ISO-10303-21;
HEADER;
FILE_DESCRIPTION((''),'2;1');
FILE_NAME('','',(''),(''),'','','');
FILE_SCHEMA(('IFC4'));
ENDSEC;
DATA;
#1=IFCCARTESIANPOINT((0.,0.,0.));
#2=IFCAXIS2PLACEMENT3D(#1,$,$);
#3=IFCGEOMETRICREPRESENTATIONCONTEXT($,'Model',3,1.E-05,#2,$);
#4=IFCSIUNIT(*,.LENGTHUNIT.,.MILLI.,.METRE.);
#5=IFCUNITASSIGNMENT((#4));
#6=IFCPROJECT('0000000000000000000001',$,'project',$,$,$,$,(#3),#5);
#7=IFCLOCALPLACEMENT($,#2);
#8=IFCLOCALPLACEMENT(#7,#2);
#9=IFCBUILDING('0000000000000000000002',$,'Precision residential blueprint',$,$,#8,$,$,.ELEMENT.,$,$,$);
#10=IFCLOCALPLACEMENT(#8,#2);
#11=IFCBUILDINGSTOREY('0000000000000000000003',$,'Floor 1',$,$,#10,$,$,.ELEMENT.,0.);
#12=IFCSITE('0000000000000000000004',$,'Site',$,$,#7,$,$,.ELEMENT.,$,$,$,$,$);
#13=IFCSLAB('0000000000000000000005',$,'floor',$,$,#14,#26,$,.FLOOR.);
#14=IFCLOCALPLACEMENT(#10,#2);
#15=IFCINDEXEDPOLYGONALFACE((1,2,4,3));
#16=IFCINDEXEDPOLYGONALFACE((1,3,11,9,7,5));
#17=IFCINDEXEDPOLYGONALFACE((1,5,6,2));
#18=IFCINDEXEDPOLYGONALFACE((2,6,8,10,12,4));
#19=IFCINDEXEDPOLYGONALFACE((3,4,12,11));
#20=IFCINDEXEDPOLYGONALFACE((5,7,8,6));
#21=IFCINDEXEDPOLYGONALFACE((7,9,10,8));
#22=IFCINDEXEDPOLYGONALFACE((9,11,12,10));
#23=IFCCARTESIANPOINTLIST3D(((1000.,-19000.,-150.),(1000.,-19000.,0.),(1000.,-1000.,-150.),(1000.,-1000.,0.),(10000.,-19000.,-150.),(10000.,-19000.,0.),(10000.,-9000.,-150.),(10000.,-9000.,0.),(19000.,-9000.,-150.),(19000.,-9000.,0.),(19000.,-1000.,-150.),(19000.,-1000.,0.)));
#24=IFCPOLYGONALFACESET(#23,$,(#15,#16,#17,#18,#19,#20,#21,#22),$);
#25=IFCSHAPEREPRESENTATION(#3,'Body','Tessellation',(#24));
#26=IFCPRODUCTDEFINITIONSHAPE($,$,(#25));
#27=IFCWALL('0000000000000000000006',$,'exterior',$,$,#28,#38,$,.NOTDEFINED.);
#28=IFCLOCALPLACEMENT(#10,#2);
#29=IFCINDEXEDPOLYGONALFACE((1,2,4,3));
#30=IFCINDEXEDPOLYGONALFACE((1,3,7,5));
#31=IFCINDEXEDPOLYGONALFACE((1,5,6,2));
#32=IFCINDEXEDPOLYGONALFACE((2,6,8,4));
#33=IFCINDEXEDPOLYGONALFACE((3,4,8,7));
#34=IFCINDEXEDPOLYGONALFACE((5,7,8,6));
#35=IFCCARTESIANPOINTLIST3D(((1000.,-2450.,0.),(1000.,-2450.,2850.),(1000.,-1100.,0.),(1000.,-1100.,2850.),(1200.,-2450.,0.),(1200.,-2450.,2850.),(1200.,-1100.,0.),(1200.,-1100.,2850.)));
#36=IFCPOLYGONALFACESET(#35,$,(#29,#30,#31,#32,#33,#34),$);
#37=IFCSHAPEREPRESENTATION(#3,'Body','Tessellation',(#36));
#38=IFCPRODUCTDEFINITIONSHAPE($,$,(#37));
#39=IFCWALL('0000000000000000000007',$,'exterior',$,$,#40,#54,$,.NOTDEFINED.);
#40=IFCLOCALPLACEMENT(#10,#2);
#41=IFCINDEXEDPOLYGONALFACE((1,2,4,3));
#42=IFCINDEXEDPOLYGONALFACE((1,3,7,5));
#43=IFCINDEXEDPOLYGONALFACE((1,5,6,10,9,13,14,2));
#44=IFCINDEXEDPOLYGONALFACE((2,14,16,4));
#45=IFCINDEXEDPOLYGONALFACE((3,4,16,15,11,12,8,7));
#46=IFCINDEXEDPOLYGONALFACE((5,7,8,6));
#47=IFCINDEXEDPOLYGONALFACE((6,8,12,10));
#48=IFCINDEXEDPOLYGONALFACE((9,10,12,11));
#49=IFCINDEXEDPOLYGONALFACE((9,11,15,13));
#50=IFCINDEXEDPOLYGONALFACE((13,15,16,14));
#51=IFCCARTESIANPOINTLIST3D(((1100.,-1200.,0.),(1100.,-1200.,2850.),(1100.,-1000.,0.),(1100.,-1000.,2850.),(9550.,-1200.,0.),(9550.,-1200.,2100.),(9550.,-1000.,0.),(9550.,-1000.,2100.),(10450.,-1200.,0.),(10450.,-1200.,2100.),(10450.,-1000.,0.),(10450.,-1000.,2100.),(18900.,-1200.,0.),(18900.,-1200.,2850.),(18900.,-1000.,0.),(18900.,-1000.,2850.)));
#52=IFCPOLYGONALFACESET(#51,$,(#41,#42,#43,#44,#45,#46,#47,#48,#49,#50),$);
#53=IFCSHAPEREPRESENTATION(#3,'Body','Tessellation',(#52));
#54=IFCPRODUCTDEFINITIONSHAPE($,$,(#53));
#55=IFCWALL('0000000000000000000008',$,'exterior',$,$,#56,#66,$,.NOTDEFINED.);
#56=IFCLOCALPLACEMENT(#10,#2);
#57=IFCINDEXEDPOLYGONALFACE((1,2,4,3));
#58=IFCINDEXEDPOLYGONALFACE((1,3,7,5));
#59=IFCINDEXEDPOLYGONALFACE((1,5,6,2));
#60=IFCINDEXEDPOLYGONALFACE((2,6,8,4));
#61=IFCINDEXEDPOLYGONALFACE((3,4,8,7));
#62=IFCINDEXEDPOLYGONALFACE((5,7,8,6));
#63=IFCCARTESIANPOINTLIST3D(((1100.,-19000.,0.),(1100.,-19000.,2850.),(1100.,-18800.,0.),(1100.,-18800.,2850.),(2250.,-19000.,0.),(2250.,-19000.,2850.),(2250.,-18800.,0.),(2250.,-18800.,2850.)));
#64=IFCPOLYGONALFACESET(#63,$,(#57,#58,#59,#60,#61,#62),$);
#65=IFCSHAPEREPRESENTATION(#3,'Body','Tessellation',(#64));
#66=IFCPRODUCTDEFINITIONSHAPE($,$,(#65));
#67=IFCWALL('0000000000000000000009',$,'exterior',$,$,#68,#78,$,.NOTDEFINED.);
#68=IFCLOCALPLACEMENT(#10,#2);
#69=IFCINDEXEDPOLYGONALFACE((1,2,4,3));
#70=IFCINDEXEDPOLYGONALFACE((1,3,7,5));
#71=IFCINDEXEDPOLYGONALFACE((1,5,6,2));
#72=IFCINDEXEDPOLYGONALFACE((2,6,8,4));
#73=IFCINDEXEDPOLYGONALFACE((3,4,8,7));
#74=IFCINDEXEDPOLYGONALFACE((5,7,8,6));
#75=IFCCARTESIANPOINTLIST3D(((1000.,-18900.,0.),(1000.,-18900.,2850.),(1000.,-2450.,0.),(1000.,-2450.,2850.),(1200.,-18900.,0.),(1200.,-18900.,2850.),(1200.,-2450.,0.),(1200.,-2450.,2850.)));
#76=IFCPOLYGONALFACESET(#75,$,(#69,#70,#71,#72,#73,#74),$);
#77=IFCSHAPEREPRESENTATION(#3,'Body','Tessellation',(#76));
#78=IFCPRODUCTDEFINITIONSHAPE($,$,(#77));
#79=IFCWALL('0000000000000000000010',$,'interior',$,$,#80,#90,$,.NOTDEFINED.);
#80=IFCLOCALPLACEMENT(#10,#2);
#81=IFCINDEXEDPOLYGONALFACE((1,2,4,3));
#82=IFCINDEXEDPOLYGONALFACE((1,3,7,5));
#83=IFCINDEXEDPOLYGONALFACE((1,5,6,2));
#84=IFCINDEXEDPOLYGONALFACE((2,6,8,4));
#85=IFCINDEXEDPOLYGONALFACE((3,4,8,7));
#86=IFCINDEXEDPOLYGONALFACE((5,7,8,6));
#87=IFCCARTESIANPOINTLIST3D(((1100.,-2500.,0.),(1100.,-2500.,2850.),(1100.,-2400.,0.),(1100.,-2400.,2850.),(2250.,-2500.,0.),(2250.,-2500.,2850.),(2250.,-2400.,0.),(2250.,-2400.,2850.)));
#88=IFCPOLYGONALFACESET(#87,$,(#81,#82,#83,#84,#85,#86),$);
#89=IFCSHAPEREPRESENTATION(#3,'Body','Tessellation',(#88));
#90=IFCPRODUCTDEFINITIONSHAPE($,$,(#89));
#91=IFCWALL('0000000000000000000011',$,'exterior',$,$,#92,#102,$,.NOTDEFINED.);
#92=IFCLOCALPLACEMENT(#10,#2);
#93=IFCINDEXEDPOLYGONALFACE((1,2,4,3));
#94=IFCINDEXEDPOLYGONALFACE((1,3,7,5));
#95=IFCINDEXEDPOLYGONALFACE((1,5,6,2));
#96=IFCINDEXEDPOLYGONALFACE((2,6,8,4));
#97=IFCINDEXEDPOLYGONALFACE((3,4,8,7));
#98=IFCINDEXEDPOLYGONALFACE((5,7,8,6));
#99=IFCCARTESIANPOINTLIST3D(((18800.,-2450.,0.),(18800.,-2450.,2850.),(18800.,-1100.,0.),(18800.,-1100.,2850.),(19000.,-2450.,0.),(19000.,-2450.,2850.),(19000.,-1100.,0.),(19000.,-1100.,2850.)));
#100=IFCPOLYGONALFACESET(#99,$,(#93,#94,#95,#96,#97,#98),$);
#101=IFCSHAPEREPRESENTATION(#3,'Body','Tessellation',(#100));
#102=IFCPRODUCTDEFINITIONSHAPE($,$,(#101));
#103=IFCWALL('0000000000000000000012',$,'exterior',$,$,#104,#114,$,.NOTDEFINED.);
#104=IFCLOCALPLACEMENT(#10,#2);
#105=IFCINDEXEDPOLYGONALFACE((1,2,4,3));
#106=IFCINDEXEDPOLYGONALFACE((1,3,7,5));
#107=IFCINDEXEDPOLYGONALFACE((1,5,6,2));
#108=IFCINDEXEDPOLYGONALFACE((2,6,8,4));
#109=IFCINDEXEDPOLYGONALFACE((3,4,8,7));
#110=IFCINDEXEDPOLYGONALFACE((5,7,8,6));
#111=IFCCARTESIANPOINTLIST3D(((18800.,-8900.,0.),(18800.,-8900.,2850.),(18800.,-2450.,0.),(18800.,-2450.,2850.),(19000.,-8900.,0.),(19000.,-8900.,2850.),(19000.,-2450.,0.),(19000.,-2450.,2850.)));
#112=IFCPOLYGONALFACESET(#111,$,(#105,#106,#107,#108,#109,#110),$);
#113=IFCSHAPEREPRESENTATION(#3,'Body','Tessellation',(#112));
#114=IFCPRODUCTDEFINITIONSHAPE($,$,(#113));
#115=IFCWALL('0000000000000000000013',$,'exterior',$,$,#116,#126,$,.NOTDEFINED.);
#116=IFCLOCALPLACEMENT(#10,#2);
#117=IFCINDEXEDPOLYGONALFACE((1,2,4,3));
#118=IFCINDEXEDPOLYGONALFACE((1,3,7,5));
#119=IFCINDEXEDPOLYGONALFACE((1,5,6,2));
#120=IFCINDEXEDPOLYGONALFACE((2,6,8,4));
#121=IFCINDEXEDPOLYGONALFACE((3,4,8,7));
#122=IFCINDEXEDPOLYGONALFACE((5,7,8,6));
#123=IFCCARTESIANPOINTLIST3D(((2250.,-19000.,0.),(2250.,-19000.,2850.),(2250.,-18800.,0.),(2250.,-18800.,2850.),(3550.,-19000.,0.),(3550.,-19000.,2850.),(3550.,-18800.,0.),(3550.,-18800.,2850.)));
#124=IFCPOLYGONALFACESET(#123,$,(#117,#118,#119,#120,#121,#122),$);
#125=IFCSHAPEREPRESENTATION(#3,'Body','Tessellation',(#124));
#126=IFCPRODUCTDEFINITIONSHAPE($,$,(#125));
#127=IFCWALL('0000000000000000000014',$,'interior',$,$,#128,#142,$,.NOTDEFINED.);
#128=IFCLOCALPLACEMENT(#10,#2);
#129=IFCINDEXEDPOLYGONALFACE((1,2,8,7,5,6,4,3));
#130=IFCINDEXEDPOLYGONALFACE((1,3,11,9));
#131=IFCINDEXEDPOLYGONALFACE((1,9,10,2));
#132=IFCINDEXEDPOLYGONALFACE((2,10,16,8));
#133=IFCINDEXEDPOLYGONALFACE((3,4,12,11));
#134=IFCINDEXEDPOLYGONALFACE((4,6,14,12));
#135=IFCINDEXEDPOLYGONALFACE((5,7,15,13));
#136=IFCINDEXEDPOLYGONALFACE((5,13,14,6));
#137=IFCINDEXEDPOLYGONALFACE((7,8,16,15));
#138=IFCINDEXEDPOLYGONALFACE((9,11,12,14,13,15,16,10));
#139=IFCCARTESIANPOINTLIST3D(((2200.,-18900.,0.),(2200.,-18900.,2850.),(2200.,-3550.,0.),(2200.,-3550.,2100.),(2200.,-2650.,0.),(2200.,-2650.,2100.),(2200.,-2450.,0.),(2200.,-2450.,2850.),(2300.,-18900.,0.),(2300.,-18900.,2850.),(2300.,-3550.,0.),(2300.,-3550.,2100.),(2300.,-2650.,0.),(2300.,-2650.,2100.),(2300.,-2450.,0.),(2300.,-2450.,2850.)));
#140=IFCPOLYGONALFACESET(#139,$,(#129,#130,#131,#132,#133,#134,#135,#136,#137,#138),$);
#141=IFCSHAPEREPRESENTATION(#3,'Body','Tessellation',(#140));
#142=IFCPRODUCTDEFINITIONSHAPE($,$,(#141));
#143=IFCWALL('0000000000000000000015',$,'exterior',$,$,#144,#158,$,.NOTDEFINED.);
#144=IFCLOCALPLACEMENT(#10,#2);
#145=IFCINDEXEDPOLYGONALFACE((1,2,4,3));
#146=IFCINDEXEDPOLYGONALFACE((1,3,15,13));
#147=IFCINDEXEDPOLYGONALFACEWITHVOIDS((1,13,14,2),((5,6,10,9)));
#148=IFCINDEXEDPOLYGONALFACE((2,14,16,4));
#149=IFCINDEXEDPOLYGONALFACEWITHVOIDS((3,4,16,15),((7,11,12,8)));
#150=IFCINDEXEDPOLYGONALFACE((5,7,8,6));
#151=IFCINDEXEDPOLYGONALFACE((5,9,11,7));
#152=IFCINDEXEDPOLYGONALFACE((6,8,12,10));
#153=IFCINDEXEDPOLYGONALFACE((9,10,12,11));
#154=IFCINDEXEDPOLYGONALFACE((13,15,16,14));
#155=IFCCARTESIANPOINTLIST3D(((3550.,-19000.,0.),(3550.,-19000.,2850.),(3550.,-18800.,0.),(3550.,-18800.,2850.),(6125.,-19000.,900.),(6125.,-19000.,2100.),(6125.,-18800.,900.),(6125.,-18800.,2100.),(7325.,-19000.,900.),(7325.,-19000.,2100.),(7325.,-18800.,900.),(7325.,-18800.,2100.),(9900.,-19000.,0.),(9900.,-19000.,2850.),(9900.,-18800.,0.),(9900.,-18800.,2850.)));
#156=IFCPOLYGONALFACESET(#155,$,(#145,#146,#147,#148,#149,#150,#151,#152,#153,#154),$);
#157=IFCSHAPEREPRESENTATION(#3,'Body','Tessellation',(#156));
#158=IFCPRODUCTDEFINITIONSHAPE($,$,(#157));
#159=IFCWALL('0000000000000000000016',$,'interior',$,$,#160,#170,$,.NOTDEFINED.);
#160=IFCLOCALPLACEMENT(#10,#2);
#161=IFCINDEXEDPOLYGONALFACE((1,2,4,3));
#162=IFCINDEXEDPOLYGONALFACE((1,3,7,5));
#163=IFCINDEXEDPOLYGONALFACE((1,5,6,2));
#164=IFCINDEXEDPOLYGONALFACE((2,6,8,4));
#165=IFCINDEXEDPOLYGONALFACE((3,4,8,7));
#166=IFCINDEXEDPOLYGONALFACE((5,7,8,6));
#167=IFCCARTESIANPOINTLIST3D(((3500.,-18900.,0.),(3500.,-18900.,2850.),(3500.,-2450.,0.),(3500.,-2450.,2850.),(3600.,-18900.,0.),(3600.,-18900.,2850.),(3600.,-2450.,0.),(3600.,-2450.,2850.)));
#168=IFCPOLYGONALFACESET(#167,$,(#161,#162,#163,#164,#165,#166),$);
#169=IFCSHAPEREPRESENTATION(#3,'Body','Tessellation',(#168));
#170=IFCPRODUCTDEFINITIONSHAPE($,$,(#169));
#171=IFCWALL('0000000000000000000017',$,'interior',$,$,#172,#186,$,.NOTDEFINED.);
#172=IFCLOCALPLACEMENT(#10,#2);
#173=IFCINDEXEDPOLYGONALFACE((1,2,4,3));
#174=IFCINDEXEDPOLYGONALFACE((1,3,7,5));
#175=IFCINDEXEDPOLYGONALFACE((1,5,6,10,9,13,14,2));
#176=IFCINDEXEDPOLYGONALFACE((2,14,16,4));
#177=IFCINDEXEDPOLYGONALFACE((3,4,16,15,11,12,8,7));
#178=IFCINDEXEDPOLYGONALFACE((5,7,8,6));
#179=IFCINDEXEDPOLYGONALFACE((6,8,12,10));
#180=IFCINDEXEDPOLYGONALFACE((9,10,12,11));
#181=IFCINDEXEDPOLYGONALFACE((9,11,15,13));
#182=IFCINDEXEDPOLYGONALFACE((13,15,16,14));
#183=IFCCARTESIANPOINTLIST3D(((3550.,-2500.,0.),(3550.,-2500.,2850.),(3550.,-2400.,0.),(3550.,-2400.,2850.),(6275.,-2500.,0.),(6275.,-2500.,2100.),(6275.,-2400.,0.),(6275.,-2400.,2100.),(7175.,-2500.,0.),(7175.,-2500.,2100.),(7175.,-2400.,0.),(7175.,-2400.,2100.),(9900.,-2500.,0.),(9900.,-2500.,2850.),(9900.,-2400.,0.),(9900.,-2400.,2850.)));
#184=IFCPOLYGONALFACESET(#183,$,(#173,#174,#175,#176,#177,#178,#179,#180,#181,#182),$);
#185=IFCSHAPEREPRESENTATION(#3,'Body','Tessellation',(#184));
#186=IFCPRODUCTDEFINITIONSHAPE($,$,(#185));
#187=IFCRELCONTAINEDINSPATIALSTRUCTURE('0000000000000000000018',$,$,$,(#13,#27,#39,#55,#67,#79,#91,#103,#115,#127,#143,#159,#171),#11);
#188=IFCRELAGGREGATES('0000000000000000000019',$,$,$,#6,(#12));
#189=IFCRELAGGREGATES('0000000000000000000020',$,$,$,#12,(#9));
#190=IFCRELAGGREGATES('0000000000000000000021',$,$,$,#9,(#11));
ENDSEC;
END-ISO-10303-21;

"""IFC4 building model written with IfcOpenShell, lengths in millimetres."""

from ifc_helpers import new_model, si_unit, frame, origin, place, context, project, spatial, polyline, outline, extrude, element, save


model = new_model("IFC4")

# Units and contexts
model_context = context("Model", 3, precision=1e-05, world=origin())
ifc_project = project(units=[si_unit("LENGTHUNIT", "METRE", prefix="MILLI")], contexts=[model_context])

# Site, building, storey
site_placement = place(None, origin())
site = spatial("IfcSite", under=ifc_project, at=site_placement, Name="Site", CompositionType="ELEMENT")
building_placement = place(site_placement, origin())
building = spatial("IfcBuilding", under=site, at=building_placement, Name="Precision residential blueprint", CompositionType="ELEMENT")
storey_placement = place(building_placement, origin())
storey = spatial("IfcBuildingStorey", under=building, at=storey_placement, Name="Floor 1", CompositionType="ELEMENT", Elevation=0.0)

# Slab
slab_placement = place(storey_placement, origin())
element("IfcSlab", 1, at=slab_placement, inside=storey, Name="floor", PredefinedType="FLOOR", context=model_context, shape_type="SweptSolid", body=[
    extrude(outline(polyline([(1000.0, -19000.0), (10000.0, -19000.0), (10000.0, -9000.0), (19000.0, -9000.0), (19000.0, -1000.0), (1000.0, -1000.0), (1000.0, -19000.0)])), frame((0.0, 0.0, -150.0)), (0.0, 0.0, 1.0), 150.0),
])

# Wall
wall_1_placement = place(storey_placement, origin())
element("IfcWall", 2, at=wall_1_placement, inside=storey, Name="exterior", PredefinedType="NOTDEFINED", context=model_context, shape_type="SweptSolid", body=[
    extrude(outline(polyline([(1200.0, -1100.0), (1200.0, -2450.0), (1000.0, -2450.0), (1000.0, -1100.0), (1200.0, -1100.0)])), origin(), (0.0, 0.0, 1.0), 2850.0),
])

# Wall, opening
wall_2_placement = place(storey_placement, origin())
wall_2 = element("IfcWall", 3, at=wall_2_placement, inside=storey, Name="exterior", PredefinedType="NOTDEFINED", context=model_context, shape_type="SweptSolid", body=[
    extrude(outline(polyline([(1100.0, -1000.0), (18900.0, -1000.0), (18900.0, -1200.0), (1100.0, -1200.0), (1100.0, -1000.0)])), origin(), (0.0, 0.0, 1.0), 2850.0),
])
opening_1_placement = place(storey_placement, origin())
element("IfcOpeningElement", 4, at=opening_1_placement, cuts=wall_2, PredefinedType="OPENING", context=model_context, shape_type="SweptSolid", body=[
    extrude(outline(polyline([(9550.0, -1000.0), (10450.0, -1000.0), (10450.0, -1200.0), (9550.0, -1200.0), (9550.0, -1000.0)])), origin(), (0.0, 0.0, 1.0), 2100.0),
])

# Walls
wall_3_placement = place(storey_placement, origin())
element("IfcWall", 5, at=wall_3_placement, inside=storey, Name="exterior", PredefinedType="NOTDEFINED", context=model_context, shape_type="SweptSolid", body=[
    extrude(outline(polyline([(1100.0, -18800.0), (2250.0, -18800.0), (2250.0, -19000.0), (1100.0, -19000.0), (1100.0, -18800.0)])), origin(), (0.0, 0.0, 1.0), 2850.0),
])
wall_4_placement = place(storey_placement, origin())
element("IfcWall", 6, at=wall_4_placement, inside=storey, Name="exterior", PredefinedType="NOTDEFINED", context=model_context, shape_type="SweptSolid", body=[
    extrude(outline(polyline([(1200.0, -2450.0), (1200.0, -18900.0), (1000.0, -18900.0), (1000.0, -2450.0), (1200.0, -2450.0)])), origin(), (0.0, 0.0, 1.0), 2850.0),
])
wall_5_placement = place(storey_placement, origin())
element("IfcWall", 7, at=wall_5_placement, inside=storey, Name="interior", PredefinedType="NOTDEFINED", context=model_context, shape_type="SweptSolid", body=[
    extrude(outline(polyline([(1100.0, -2400.0), (2250.0, -2400.0), (2250.0, -2500.0), (1100.0, -2500.0), (1100.0, -2400.0)])), origin(), (0.0, 0.0, 1.0), 2850.0),
])
wall_6_placement = place(storey_placement, origin())
element("IfcWall", 8, at=wall_6_placement, inside=storey, Name="exterior", PredefinedType="NOTDEFINED", context=model_context, shape_type="SweptSolid", body=[
    extrude(outline(polyline([(19000.0, -1100.0), (19000.0, -2450.0), (18800.0, -2450.0), (18800.0, -1100.0), (19000.0, -1100.0)])), origin(), (0.0, 0.0, 1.0), 2850.0),
])
wall_7_placement = place(storey_placement, origin())
element("IfcWall", 9, at=wall_7_placement, inside=storey, Name="exterior", PredefinedType="NOTDEFINED", context=model_context, shape_type="SweptSolid", body=[
    extrude(outline(polyline([(19000.0, -2450.0), (19000.0, -8900.0), (18800.0, -8900.0), (18800.0, -2450.0), (19000.0, -2450.0)])), origin(), (0.0, 0.0, 1.0), 2850.0),
])
wall_8_placement = place(storey_placement, origin())
element("IfcWall", 10, at=wall_8_placement, inside=storey, Name="exterior", PredefinedType="NOTDEFINED", context=model_context, shape_type="SweptSolid", body=[
    extrude(outline(polyline([(2250.0, -18800.0), (3550.0, -18800.0), (3550.0, -19000.0), (2250.0, -19000.0), (2250.0, -18800.0)])), origin(), (0.0, 0.0, 1.0), 2850.0),
])

# Walls, openings
wall_9_placement = place(storey_placement, origin())
wall_9 = element("IfcWall", 11, at=wall_9_placement, inside=storey, Name="interior", PredefinedType="NOTDEFINED", context=model_context, shape_type="SweptSolid", body=[
    extrude(outline(polyline([(2300.0, -2450.0), (2300.0, -18900.0), (2200.0, -18900.0), (2200.0, -2450.0), (2300.0, -2450.0)])), origin(), (0.0, 0.0, 1.0), 2850.0),
])
opening_2_placement = place(storey_placement, origin())
element("IfcOpeningElement", 12, at=opening_2_placement, cuts=wall_9, PredefinedType="OPENING", context=model_context, shape_type="SweptSolid", body=[
    extrude(outline(polyline([(2300.0, -2650.0), (2300.0, -3550.0), (2200.0, -3550.0), (2200.0, -2650.0), (2300.0, -2650.0)])), origin(), (0.0, 0.0, 1.0), 2100.0),
])
wall_10_placement = place(storey_placement, origin())
wall_10 = element("IfcWall", 13, at=wall_10_placement, inside=storey, Name="exterior", PredefinedType="NOTDEFINED", context=model_context, shape_type="SweptSolid", body=[
    extrude(outline(polyline([(3550.0, -18800.0), (9900.0, -18800.0), (9900.0, -19000.0), (3550.0, -19000.0), (3550.0, -18800.0)])), origin(), (0.0, 0.0, 1.0), 2850.0),
])
opening_3_placement = place(storey_placement, origin())
element("IfcOpeningElement", 14, at=opening_3_placement, cuts=wall_10, PredefinedType="OPENING", context=model_context, shape_type="SweptSolid", body=[
    extrude(outline(polyline([(6125.0, -18800.0), (7325.0, -18800.0), (7325.0, -19000.0), (6125.0, -19000.0), (6125.0, -18800.0)])), frame((0.0, 0.0, 900.0)), (0.0, 0.0, 1.0), 1200.0),
])

# Wall
wall_11_placement = place(storey_placement, origin())
element("IfcWall", 15, at=wall_11_placement, inside=storey, Name="interior", PredefinedType="NOTDEFINED", context=model_context, shape_type="SweptSolid", body=[
    extrude(outline(polyline([(3600.0, -2450.0), (3600.0, -18900.0), (3500.0, -18900.0), (3500.0, -2450.0), (3600.0, -2450.0)])), origin(), (0.0, 0.0, 1.0), 2850.0),
])

# Wall, opening
wall_12_placement = place(storey_placement, origin())
wall_12 = element("IfcWall", 16, at=wall_12_placement, inside=storey, Name="interior", PredefinedType="NOTDEFINED", context=model_context, shape_type="SweptSolid", body=[
    extrude(outline(polyline([(3550.0, -2400.0), (9900.0, -2400.0), (9900.0, -2500.0), (3550.0, -2500.0), (3550.0, -2400.0)])), origin(), (0.0, 0.0, 1.0), 2850.0),
])
opening_4_placement = place(storey_placement, origin())
element("IfcOpeningElement", 17, at=opening_4_placement, cuts=wall_12, PredefinedType="OPENING", context=model_context, shape_type="SweptSolid", body=[
    extrude(outline(polyline([(6275.0, -2400.0), (7175.0, -2400.0), (7175.0, -2500.0), (6275.0, -2500.0), (6275.0, -2400.0)])), origin(), (0.0, 0.0, 1.0), 2100.0),
])

save(model, "model.ifc")
